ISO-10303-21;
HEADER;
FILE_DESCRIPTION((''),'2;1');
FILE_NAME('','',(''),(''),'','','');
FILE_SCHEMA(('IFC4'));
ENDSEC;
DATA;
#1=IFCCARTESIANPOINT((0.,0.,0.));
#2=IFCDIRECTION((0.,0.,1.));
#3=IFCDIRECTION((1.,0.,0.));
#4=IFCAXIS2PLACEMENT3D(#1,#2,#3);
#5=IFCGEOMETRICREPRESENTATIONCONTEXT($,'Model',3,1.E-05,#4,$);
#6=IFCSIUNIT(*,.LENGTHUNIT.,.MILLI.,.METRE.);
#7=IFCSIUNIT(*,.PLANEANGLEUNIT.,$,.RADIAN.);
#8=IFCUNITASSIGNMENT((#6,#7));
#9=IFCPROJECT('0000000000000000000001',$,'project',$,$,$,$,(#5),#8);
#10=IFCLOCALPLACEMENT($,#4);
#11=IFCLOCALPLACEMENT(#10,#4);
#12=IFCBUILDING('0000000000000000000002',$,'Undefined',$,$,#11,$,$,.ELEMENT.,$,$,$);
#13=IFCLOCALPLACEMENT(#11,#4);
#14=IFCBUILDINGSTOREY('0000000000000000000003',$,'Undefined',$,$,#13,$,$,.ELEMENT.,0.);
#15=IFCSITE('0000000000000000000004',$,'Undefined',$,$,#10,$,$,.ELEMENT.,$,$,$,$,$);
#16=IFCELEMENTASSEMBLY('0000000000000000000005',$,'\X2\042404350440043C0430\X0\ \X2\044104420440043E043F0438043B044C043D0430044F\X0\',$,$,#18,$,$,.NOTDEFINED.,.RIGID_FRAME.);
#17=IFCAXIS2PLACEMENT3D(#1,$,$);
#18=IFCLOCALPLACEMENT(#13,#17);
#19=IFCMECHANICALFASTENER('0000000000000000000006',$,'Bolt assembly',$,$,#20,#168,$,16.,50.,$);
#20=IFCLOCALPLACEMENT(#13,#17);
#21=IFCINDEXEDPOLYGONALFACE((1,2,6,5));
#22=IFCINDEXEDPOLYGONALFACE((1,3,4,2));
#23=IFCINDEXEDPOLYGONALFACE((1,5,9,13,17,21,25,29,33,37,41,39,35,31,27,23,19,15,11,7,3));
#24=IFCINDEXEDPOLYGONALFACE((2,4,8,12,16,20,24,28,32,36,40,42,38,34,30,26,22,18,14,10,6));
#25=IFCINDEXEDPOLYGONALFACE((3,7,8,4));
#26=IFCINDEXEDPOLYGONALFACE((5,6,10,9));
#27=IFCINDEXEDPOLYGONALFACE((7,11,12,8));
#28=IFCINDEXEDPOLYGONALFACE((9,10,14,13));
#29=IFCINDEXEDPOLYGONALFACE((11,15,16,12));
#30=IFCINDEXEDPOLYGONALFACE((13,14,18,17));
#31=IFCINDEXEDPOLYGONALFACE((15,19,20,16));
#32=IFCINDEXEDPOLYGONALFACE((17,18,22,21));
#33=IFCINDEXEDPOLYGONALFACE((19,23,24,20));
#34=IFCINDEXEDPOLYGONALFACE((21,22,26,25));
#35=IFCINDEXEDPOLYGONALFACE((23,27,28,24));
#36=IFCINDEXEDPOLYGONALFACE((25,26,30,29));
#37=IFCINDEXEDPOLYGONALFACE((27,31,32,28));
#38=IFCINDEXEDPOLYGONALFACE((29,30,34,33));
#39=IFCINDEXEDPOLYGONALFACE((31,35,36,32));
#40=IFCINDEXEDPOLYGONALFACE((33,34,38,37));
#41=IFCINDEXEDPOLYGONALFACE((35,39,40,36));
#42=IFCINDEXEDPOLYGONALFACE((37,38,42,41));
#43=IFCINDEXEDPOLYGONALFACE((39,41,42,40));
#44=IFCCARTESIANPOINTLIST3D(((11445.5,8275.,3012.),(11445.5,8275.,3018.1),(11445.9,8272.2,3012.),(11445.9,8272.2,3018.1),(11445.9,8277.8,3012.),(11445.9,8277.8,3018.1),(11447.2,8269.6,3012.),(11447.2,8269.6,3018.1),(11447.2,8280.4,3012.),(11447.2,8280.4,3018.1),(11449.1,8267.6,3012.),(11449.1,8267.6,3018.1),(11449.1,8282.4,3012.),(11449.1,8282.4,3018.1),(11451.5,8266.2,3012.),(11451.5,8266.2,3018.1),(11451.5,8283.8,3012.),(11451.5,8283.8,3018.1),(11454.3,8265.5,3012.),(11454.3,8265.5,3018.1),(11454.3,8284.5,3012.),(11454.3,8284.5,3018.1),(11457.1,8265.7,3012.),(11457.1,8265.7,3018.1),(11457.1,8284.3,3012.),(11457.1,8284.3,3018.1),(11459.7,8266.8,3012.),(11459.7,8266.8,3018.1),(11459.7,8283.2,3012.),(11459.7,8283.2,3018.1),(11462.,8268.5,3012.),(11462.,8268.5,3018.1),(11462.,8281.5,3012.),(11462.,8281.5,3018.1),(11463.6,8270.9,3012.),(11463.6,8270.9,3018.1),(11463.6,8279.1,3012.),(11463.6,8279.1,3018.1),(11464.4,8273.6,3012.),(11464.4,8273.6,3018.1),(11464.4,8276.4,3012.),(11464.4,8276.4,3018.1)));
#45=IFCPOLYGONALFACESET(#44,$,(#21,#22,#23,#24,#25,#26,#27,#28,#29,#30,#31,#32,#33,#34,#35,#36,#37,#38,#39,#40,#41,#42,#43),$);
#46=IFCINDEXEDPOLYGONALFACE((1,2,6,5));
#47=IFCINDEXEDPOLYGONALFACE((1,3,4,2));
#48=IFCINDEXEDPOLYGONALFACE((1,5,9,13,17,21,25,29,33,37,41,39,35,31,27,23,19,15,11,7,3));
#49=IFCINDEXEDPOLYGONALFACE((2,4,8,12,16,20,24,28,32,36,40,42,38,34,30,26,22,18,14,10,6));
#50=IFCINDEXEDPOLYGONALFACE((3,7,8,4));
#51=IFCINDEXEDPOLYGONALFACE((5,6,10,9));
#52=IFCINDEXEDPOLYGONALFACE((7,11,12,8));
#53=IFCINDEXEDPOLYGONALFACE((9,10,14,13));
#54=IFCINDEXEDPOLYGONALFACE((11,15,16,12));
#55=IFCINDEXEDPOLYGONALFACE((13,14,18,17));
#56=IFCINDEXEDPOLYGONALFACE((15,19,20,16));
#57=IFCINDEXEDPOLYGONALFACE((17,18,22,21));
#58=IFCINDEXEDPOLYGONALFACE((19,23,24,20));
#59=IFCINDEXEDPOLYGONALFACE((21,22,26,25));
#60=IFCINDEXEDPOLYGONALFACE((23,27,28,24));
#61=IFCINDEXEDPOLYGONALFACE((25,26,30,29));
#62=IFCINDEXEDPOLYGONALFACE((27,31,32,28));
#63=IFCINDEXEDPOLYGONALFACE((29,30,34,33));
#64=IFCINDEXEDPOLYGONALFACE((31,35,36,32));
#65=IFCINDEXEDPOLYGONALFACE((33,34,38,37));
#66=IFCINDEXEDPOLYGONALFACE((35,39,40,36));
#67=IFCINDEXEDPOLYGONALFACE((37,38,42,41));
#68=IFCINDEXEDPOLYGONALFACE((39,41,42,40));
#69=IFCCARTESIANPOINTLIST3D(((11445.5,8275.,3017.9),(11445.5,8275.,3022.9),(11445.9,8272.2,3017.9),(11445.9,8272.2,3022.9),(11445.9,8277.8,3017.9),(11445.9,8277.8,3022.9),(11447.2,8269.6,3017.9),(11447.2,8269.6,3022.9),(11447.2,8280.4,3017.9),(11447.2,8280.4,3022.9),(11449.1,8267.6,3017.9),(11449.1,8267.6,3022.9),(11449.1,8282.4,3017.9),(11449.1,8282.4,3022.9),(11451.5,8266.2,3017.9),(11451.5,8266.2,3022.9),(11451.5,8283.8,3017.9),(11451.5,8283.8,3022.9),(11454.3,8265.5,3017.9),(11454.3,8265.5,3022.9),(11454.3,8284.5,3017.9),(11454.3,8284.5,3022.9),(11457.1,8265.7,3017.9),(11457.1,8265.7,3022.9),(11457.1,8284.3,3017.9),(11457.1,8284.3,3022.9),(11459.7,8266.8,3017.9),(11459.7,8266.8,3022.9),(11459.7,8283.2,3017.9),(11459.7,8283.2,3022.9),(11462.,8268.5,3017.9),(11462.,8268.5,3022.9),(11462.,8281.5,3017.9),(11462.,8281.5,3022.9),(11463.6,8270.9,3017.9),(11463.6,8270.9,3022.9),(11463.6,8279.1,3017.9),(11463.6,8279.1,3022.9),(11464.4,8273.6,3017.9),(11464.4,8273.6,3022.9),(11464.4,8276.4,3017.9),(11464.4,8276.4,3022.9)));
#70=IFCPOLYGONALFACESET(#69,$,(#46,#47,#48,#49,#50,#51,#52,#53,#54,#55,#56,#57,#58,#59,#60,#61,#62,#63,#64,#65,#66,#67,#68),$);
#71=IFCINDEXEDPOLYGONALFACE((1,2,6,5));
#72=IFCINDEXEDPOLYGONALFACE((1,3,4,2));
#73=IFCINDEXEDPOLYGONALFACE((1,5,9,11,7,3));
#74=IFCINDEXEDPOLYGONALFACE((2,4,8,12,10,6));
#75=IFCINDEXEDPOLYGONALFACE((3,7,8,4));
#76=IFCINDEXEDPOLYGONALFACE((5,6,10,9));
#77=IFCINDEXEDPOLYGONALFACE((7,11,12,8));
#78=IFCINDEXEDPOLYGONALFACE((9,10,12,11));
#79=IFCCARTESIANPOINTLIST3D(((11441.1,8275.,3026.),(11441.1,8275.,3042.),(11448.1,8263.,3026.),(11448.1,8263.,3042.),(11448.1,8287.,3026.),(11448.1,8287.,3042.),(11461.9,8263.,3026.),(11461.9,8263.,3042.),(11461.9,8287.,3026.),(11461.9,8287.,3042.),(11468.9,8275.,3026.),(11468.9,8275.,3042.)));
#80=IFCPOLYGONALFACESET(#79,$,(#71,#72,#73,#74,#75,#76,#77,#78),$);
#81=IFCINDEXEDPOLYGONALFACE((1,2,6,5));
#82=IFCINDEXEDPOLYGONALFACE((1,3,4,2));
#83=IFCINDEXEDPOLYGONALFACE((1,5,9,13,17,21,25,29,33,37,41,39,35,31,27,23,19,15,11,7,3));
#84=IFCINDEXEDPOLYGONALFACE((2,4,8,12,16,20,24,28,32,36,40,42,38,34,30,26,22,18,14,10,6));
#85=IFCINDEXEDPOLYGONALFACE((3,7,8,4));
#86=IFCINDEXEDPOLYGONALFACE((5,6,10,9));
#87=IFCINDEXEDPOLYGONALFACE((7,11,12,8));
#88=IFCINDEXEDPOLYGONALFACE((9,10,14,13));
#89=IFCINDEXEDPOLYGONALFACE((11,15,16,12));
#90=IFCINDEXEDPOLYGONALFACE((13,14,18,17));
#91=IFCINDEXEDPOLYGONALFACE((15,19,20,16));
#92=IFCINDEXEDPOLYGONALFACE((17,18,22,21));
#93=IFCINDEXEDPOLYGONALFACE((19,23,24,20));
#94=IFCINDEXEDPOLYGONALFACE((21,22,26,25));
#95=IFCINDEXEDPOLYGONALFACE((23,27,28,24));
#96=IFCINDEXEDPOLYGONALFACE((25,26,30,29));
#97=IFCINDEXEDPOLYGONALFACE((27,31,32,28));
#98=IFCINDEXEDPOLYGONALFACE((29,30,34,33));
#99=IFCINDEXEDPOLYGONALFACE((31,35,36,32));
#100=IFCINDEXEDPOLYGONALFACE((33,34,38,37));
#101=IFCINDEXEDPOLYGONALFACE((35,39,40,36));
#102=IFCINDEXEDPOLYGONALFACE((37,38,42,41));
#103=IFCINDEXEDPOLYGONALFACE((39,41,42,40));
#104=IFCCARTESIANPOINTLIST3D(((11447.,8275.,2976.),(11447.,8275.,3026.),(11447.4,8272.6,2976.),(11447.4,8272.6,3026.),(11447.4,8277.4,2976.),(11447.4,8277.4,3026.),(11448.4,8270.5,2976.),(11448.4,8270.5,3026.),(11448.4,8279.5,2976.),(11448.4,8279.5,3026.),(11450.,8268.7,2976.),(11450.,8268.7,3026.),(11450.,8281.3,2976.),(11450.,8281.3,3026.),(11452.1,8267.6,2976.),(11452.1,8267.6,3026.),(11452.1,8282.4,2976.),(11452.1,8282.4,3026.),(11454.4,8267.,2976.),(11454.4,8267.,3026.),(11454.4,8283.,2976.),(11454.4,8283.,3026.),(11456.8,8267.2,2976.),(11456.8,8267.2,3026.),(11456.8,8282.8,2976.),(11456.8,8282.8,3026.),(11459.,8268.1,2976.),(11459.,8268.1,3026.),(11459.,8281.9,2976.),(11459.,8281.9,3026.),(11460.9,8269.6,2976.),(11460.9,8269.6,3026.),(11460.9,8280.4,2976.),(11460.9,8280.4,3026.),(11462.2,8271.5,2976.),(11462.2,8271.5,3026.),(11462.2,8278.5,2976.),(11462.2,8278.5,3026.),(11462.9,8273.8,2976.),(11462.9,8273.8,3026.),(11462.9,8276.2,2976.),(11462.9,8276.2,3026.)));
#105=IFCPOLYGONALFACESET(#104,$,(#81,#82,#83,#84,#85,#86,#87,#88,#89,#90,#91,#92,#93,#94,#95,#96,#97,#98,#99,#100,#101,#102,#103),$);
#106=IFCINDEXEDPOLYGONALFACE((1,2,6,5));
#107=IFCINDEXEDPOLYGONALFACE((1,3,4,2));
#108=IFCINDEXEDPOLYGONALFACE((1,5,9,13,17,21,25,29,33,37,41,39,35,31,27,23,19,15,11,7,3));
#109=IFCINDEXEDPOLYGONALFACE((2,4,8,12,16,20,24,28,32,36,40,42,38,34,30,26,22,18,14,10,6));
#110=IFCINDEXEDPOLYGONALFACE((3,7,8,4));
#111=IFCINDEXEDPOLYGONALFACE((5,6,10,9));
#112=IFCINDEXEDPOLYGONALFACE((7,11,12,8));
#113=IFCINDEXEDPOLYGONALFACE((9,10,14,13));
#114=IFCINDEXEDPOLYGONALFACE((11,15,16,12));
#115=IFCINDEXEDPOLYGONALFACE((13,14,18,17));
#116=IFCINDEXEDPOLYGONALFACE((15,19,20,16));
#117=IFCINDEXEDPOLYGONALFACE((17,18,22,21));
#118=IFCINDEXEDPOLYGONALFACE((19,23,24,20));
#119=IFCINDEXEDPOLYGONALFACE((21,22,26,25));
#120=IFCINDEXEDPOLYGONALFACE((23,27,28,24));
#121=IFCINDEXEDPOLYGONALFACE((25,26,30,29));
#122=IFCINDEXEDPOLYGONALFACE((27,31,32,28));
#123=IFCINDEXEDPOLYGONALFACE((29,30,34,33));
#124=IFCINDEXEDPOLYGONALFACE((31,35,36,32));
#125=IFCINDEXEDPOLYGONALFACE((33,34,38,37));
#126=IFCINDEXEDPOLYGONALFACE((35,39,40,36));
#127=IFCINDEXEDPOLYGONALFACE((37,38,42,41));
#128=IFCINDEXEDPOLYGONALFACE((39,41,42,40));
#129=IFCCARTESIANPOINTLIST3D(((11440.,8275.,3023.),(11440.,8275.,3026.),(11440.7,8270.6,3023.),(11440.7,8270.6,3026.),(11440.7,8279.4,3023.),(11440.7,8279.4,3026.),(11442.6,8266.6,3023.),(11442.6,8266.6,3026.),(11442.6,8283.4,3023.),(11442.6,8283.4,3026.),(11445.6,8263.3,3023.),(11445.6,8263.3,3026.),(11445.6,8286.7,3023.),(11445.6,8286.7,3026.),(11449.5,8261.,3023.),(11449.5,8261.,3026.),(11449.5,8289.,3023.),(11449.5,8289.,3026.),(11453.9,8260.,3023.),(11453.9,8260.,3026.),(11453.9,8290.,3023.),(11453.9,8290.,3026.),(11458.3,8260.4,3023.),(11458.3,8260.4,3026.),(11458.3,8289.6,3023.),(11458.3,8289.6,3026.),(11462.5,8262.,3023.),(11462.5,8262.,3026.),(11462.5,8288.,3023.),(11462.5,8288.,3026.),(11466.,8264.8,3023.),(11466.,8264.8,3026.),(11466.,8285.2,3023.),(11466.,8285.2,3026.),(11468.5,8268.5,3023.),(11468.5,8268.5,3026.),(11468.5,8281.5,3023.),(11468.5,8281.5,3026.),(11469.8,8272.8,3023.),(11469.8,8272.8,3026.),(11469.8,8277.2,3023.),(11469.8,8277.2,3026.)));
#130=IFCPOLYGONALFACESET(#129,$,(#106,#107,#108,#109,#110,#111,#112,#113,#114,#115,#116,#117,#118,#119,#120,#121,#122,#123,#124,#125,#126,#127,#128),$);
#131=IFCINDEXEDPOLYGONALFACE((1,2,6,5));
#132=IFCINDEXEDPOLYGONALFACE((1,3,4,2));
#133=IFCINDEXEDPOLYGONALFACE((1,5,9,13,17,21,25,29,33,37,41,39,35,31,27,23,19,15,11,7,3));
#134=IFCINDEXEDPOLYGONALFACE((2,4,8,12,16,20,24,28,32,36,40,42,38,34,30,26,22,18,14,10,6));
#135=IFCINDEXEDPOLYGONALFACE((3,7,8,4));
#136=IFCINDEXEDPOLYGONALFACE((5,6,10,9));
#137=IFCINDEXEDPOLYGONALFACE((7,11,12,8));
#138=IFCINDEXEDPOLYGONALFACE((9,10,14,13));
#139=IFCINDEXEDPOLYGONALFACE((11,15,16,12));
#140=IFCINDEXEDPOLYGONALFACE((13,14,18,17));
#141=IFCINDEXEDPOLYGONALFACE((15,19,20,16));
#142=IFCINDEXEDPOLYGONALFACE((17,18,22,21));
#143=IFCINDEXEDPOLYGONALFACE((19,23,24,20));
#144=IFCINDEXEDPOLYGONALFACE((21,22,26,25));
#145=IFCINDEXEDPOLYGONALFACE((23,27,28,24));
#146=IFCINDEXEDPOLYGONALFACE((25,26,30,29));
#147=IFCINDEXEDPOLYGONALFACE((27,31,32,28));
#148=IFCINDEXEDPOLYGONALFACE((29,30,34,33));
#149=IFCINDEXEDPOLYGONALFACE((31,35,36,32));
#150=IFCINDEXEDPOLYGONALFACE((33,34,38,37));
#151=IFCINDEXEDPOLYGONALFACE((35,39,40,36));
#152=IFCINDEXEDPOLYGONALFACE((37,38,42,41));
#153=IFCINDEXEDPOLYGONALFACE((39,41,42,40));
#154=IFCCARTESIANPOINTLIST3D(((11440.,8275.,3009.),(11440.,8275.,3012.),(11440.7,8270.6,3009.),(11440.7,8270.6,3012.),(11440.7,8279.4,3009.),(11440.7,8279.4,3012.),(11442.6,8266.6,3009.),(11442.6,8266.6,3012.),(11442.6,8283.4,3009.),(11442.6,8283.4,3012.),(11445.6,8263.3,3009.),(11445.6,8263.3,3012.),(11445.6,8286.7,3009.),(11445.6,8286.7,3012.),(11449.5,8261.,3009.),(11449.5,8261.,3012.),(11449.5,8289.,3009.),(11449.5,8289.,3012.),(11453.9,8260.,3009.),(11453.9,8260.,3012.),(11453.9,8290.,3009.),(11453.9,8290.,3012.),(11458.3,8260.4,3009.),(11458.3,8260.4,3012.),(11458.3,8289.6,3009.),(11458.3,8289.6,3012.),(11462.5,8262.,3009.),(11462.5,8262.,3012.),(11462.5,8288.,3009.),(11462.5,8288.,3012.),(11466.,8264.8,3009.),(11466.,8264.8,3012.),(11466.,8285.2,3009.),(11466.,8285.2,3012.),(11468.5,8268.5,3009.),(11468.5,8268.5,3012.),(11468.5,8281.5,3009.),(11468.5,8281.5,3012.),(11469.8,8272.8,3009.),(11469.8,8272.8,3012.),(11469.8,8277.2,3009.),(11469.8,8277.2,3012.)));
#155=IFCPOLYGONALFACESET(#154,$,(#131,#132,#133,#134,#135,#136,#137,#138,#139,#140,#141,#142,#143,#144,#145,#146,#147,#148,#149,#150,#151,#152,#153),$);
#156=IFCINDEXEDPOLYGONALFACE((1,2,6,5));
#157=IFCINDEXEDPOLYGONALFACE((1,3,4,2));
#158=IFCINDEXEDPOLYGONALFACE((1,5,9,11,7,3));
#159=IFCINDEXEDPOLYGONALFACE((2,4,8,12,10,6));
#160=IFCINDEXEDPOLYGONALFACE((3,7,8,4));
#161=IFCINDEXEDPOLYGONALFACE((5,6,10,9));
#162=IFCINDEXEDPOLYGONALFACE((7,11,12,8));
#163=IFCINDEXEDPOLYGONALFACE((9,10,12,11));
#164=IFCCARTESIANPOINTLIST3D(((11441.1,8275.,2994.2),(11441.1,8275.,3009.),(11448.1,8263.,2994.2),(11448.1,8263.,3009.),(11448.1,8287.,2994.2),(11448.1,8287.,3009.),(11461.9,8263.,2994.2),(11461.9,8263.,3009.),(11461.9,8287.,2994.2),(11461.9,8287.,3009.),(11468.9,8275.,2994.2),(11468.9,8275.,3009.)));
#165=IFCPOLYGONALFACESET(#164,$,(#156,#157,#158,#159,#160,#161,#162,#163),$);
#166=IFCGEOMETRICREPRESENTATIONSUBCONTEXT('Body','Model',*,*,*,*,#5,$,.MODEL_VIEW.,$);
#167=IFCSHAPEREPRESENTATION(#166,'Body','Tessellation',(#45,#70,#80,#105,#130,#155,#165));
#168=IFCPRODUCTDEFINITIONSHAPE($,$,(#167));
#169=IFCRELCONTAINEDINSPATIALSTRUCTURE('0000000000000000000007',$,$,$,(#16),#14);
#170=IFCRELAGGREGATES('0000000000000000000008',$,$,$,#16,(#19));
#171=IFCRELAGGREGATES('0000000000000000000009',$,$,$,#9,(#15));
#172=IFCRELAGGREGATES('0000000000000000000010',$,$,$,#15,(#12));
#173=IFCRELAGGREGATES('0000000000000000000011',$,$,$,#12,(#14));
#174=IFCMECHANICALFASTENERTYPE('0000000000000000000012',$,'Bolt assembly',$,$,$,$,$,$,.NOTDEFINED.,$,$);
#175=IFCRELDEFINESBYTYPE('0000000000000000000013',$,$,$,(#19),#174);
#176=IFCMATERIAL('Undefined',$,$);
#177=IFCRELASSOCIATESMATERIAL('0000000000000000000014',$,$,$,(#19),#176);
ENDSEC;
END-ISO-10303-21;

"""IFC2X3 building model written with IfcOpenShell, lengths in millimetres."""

from ifc_helpers import new_model, si_unit, frame, origin_with_axes, origin_2d_with_axis, place, context, subcontext, project, spatial, polyline, circle, outline, extrude, source, transform, mapped, material, type_object, element, aggregate, save


model = new_model("IFC2X3")

# Units and contexts
model_context = context("Model", 3, precision=1e-05, world=origin_with_axes())
body_context = subcontext(model_context, "Body", "Model", "MODEL_VIEW")
ifc_project = project(units=[si_unit("LENGTHUNIT", "METRE", prefix="MILLI"), si_unit("PLANEANGLEUNIT", "RADIAN")], contexts=[model_context])

# Site, building, storey
site_placement = place(None, origin_with_axes())
site = spatial("IfcSite", under=ifc_project, at=site_placement, Name="Undefined", CompositionType="ELEMENT")
building_placement = place(site_placement, origin_with_axes())
building = spatial("IfcBuilding", under=site, at=building_placement, Name="Undefined", CompositionType="ELEMENT")
storey_placement = place(building_placement, origin_with_axes())
storey = spatial("IfcBuildingStorey", under=building, at=storey_placement, Name="Undefined", CompositionType="ELEMENT", Elevation=0.0)

# Element assembly
assembly_1_placement = place(storey_placement, origin_with_axes())
assembly_1 = element("IfcElementAssembly", 1, at=assembly_1_placement, inside=storey, Name="Ферма стропильная", AssemblyPlace="NOTDEFINED", PredefinedType="RIGID_FRAME")

# Mechanical fastener
ifc_material_1 = material(Name="Undefined")
mechanical_fastener_type = type_object("IfcMechanicalFastenerType", Name="Bolt assembly")
shared_shape_1 = source(origin_with_axes(), body_context, "Body", "SweptSolid", [
    extrude(circle(Radius=9.5, at=origin_2d_with_axis()), frame((0.0, -0.1, 0.0), z_axis=(0.0, 1.0, 0.0), x_axis=(1.0, 0.0, 0.0)), (0.0, 0.0, 1.0), 6.1),
    extrude(circle(Radius=9.5, at=origin_2d_with_axis()), frame((0.0, -4.9, 0.0), z_axis=(0.0, 1.0, 0.0), x_axis=(1.0, 0.0, 0.0)), (0.0, 0.0, 1.0), 5.0),
    extrude(outline(polyline([(13.9, 0.0), (6.9, 12.0), (-6.9, 12.0), (-13.9, 0.0), (-6.9, -12.0), (6.9, -12.0), (13.9, 0.0)])), frame((0.0, -24.0, 0.0), z_axis=(0.0, 1.0, 0.0), x_axis=(1.0, 0.0, 0.0)), (0.0, 0.0, 1.0), 16.0),
    extrude(circle(Radius=8.0, at=origin_2d_with_axis()), frame((0.0, -8.0, 0.0), z_axis=(0.0, 1.0, 0.0), x_axis=(1.0, 0.0, 0.0)), (0.0, 0.0, 1.0), 50.0),
    extrude(circle(Radius=15.0, at=origin_2d_with_axis()), frame((0.0, -8.0, 0.0), z_axis=(0.0, 1.0, 0.0), x_axis=(1.0, 0.0, 0.0)), (0.0, 0.0, 1.0), 3.0),
    extrude(circle(Radius=15.0, at=origin_2d_with_axis()), frame((0.0, 6.0, 0.0), z_axis=(0.0, 1.0, 0.0), x_axis=(1.0, 0.0, 0.0)), (0.0, 0.0, 1.0), 3.0),
    extrude(outline(polyline([(13.9, 0.0), (6.9, 12.0), (-6.9, 12.0), (-13.9, 0.0), (-6.9, -12.0), (6.9, -12.0), (13.9, 0.0)])), frame((0.0, 9.0, 0.0), z_axis=(0.0, 1.0, 0.0), x_axis=(1.0, 0.0, 0.0)), (0.0, 0.0, 1.0), 14.8),
])
mechanical_fastener_1_placement = place(assembly_1_placement, frame((11455.0, 8275.0, 3018.0), z_axis=(0.0, -1.0, 0.0), x_axis=(-1.0, 0.0, 0.0)))
mechanical_fastener_1 = element("IfcMechanicalFastener", 2, at=mechanical_fastener_1_placement, type_object=mechanical_fastener_type, material=ifc_material_1, Name="Bolt assembly", NominalDiameter=16.0, NominalLength=50.0, context=body_context, shape_type="MappedRepresentation", body=[
    mapped(shared_shape_1, transform((0.0, 0.0, 0.0))),
])
aggregate(assembly_1, [mechanical_fastener_1])

save(model, "model.ifc")
